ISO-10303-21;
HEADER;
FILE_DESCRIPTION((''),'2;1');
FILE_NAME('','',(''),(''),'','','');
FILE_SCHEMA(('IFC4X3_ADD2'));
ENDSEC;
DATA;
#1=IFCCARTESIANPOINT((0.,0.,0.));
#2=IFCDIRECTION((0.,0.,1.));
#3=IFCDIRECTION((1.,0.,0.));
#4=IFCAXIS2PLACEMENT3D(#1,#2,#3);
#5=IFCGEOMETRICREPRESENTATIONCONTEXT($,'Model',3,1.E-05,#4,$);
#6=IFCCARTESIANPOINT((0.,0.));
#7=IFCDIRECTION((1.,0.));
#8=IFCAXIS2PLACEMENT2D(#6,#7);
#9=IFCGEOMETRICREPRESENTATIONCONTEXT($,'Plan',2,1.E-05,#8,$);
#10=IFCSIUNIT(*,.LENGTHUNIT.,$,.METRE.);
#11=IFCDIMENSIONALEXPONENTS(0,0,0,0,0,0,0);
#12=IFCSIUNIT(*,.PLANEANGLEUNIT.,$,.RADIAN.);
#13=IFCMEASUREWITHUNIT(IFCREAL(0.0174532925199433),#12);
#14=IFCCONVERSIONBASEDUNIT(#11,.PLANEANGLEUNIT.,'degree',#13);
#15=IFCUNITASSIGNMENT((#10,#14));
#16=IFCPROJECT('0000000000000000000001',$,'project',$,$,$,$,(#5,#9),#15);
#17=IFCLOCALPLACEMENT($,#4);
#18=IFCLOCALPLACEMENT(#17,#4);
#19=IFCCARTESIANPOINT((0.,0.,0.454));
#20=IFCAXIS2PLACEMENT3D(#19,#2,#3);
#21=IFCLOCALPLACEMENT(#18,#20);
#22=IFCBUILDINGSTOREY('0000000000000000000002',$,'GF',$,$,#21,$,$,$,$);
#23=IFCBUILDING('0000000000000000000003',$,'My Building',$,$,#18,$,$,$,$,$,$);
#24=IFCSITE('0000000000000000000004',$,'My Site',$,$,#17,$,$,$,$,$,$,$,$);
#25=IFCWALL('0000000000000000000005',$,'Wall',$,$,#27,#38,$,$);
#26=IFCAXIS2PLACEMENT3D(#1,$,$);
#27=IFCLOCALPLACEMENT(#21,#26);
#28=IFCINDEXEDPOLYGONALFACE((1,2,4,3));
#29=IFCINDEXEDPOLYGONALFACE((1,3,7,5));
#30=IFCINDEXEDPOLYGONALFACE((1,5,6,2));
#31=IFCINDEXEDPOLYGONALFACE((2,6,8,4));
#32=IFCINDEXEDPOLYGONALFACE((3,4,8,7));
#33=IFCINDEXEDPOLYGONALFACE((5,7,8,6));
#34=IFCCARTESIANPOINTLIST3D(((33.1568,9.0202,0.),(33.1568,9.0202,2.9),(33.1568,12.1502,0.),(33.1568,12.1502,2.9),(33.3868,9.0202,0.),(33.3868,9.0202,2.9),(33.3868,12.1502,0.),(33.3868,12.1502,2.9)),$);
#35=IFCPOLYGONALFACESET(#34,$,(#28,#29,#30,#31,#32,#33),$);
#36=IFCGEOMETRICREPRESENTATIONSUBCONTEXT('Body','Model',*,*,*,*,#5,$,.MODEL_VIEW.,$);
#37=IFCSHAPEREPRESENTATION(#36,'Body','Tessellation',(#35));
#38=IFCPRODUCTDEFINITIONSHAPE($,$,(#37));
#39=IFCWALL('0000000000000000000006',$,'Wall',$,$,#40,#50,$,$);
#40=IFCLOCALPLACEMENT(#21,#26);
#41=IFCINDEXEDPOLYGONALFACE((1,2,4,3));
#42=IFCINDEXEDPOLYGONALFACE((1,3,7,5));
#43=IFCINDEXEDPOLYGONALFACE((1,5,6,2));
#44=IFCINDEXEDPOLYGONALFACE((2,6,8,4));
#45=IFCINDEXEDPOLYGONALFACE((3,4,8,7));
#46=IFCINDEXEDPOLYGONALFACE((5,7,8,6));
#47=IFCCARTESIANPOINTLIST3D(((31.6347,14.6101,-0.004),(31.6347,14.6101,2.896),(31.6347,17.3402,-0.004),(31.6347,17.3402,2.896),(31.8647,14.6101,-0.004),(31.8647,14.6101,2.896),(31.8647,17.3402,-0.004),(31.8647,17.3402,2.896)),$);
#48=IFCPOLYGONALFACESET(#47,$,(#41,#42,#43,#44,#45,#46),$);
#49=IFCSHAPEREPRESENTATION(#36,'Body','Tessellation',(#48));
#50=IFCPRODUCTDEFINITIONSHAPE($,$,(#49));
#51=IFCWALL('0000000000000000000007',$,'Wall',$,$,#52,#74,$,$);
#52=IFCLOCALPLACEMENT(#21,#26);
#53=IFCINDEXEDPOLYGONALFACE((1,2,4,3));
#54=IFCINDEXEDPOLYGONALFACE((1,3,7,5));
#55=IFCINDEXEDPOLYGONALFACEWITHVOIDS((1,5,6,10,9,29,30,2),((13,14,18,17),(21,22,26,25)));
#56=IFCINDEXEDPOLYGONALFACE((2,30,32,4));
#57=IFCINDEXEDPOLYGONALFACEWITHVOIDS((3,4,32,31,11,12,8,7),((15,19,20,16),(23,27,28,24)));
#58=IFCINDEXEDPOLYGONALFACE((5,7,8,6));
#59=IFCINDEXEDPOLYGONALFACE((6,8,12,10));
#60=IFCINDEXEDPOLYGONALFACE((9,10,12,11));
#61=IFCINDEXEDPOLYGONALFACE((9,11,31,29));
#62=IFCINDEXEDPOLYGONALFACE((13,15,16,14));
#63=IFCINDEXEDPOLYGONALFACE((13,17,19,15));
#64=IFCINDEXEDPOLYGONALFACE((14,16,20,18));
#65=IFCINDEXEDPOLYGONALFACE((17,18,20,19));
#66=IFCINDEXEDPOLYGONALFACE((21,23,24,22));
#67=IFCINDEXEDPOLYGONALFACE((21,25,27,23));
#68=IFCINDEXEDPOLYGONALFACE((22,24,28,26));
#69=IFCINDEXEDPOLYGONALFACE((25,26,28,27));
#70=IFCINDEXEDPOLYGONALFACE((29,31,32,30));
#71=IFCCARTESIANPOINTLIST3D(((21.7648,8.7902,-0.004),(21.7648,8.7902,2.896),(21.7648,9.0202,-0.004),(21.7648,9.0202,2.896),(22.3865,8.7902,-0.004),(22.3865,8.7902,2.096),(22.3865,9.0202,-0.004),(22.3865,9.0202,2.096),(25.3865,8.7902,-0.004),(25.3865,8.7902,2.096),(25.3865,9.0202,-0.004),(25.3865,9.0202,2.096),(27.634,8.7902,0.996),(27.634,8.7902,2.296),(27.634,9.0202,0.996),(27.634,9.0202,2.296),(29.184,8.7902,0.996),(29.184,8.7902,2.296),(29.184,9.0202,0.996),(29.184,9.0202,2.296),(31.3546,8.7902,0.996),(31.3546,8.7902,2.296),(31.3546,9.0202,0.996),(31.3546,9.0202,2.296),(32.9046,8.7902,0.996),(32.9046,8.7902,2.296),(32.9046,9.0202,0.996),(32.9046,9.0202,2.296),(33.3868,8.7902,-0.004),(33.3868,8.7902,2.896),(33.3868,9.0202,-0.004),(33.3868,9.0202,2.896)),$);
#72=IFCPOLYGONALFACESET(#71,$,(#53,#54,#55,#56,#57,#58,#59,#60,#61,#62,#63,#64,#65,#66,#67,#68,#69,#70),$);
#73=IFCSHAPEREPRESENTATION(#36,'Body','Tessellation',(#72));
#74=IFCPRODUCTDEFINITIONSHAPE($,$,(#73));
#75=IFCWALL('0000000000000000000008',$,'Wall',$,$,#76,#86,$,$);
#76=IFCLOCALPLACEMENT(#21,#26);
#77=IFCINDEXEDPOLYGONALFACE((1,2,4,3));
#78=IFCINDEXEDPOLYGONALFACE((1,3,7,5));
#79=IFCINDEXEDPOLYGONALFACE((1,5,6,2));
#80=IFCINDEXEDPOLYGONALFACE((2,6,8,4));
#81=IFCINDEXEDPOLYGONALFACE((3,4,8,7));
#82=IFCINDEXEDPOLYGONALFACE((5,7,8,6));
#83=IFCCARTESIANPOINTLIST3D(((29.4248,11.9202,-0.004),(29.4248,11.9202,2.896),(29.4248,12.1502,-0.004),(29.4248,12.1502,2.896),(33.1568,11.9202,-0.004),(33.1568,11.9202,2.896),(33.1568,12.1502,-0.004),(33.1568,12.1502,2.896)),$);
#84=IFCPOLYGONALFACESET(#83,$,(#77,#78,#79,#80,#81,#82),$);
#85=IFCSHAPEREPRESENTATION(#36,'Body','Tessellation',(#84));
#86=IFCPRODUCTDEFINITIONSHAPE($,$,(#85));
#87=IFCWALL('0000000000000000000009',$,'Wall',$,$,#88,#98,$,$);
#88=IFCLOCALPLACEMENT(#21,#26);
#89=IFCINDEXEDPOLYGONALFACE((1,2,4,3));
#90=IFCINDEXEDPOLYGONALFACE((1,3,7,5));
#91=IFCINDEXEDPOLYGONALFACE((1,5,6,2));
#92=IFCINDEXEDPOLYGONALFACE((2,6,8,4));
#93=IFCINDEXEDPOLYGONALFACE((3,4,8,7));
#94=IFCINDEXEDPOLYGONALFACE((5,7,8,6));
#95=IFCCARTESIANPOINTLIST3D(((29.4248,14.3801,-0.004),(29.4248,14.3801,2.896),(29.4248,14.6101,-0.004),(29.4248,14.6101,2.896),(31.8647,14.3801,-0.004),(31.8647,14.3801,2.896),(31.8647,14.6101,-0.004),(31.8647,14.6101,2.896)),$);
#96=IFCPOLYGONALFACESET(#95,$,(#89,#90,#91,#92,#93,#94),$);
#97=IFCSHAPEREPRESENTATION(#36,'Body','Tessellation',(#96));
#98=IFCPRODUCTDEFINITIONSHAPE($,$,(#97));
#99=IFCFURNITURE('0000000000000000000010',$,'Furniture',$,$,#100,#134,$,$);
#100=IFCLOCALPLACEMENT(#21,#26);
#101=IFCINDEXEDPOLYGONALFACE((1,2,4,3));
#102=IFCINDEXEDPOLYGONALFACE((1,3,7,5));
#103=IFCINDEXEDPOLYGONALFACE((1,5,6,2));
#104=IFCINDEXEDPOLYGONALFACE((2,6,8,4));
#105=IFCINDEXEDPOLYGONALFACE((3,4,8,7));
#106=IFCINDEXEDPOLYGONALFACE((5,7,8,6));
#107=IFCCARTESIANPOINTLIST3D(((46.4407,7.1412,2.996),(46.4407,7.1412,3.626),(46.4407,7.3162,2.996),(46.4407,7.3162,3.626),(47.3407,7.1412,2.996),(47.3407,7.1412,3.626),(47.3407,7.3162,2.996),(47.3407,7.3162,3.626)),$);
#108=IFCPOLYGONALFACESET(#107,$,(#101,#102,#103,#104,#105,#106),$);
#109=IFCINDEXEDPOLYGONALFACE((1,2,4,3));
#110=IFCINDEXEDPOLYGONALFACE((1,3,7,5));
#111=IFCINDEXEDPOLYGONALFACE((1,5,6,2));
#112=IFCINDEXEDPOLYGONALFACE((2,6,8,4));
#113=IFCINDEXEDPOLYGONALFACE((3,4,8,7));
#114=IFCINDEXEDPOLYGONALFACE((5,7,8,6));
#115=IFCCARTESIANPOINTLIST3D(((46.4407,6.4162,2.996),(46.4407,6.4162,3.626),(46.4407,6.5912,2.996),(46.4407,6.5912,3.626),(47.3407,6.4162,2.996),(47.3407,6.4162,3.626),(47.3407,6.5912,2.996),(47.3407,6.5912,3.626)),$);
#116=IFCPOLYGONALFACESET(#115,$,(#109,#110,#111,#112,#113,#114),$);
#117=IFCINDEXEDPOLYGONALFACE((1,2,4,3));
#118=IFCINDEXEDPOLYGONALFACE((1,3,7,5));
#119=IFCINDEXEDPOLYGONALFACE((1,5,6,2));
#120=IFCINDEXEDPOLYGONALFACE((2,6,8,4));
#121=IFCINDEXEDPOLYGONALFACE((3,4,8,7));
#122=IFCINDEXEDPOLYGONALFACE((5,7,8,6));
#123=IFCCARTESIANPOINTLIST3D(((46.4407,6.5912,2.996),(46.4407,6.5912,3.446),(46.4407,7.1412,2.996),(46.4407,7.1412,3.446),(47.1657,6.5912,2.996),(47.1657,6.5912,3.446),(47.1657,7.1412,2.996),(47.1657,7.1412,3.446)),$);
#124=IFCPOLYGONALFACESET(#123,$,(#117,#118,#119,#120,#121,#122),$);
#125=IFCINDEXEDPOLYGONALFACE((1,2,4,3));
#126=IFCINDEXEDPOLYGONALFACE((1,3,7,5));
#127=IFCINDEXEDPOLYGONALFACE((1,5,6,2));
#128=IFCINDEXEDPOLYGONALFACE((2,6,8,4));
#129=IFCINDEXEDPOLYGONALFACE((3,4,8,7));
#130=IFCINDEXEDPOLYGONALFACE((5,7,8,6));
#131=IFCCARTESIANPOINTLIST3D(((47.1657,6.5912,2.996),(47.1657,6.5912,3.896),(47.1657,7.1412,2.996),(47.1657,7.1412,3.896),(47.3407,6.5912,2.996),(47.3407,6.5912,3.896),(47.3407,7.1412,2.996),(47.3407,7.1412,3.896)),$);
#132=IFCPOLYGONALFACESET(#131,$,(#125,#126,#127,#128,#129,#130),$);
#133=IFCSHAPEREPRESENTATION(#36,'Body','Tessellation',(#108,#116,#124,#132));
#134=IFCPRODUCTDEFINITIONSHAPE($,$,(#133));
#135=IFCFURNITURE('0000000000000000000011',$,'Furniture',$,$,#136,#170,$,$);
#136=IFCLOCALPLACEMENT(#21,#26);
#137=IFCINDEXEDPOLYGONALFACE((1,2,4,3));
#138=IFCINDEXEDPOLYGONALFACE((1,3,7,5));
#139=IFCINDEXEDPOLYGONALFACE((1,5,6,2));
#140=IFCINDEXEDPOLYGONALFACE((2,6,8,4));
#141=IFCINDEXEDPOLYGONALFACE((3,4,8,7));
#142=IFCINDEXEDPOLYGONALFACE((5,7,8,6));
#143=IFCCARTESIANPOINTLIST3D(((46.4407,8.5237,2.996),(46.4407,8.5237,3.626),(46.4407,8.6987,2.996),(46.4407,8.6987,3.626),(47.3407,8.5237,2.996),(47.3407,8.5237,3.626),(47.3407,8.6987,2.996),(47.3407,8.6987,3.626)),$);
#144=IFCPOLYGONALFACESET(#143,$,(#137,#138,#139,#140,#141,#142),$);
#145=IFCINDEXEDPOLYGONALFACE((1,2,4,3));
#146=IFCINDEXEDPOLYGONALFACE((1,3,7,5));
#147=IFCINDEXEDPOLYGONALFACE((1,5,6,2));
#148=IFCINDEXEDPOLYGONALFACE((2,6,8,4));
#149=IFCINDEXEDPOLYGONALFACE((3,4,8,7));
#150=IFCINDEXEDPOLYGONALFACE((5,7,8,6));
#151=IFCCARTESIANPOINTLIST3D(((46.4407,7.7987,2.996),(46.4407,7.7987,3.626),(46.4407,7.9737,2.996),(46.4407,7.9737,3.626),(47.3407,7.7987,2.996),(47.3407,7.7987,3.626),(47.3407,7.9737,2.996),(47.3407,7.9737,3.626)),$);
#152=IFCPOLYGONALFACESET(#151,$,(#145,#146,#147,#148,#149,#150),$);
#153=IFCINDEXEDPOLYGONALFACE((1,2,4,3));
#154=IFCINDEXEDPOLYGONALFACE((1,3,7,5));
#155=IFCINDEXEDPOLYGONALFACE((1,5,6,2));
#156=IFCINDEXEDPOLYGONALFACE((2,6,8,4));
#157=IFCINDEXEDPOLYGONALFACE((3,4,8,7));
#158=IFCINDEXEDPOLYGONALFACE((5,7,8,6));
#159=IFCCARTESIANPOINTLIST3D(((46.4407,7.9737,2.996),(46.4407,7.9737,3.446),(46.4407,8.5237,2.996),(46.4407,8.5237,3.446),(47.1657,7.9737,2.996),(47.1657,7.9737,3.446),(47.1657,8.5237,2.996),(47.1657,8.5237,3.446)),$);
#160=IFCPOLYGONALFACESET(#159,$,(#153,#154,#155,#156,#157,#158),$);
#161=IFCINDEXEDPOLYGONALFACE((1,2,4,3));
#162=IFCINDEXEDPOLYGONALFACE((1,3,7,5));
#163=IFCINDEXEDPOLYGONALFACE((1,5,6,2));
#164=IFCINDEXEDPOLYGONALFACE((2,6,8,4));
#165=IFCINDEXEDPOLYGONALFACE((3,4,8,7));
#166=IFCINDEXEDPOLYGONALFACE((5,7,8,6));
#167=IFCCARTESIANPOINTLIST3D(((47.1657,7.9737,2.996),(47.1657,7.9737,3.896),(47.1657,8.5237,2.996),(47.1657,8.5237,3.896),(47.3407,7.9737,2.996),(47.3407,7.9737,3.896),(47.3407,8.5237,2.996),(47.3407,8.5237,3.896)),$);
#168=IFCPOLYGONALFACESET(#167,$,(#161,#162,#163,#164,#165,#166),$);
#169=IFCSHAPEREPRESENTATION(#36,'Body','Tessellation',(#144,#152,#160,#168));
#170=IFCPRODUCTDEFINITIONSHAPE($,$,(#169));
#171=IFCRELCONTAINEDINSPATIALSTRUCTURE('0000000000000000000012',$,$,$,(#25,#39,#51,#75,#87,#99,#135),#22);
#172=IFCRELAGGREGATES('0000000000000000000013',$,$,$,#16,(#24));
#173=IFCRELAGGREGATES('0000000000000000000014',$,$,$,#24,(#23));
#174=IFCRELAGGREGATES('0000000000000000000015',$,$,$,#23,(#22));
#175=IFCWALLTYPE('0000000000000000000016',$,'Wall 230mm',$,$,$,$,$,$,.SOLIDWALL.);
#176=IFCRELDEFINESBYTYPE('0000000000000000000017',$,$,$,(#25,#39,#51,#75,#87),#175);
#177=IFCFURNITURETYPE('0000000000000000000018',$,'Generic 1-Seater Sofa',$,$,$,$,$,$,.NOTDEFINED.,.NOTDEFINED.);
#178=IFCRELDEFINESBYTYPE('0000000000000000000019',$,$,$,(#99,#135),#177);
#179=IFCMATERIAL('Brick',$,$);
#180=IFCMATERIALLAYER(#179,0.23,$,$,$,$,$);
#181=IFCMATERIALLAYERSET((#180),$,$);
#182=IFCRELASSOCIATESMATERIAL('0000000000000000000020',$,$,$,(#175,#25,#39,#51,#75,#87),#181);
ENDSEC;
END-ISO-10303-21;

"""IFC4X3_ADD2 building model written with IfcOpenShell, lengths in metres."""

from ifc_helpers import new_model, entity, si_unit, converted_unit, frame, origin_with_axes, origin_2d_with_axis, place, context, subcontext, project, spatial, line, indexed_curve, outline, extrude, shape, source, transform, mapped, material, layer, layer_set, layer_usage, type_object, type_shapes, element, save


model = new_model("IFC4X3_ADD2")

# Units and contexts
model_context = context("Model", 3, precision=1e-05, world=origin_with_axes())
plan_context = context("Plan", 2, precision=1e-05, world=origin_2d_with_axis())
body_context_1 = subcontext(model_context, "Body", "Model", "MODEL_VIEW")
body_context_2 = subcontext(plan_context, "Body", "Plan", "PLAN_VIEW")
ifc_project = project(units=[si_unit("LENGTHUNIT", "METRE"), converted_unit("PLANEANGLEUNIT", "degree", entity("IfcReal", 0.0174532925199433), si_unit("PLANEANGLEUNIT", "RADIAN"), dimensions=[0, 0, 0, 0, 0, 0, 0])], contexts=[model_context, plan_context])

# Site, building, storey
site_placement = place(None, origin_with_axes())
site = spatial("IfcSite", under=ifc_project, at=site_placement, Name="My Site")
building_placement = place(site_placement, origin_with_axes())
building = spatial("IfcBuilding", under=site, at=building_placement, Name="My Building")
storey_placement = place(building_placement, frame((0.0, 0.0, 0.454), z_axis=(0.0, 0.0, 1.0), x_axis=(1.0, 0.0, 0.0)))
storey = spatial("IfcBuildingStorey", under=building, at=storey_placement, Name="GF")

# Walls
ifc_material = material(Name="Brick")
ifc_layer = layer(ifc_material, 0.23)
ifc_layer_set = layer_set([ifc_layer])
ifc_layer_usage_1 = layer_usage(ifc_layer_set, "AXIS2", "POSITIVE", 0.0)
wall_type = type_object("IfcWallType", Name="Wall 230mm", PredefinedType="SOLIDWALL", material=ifc_layer_set)
wall_1_placement = place(storey_placement, frame((33.3868, 9.0202, 0.0), z_axis=(0.0, 0.0, 1.0), x_axis=(0.000001, 1.0, 0.0)))
element("IfcWall", 1, at=wall_1_placement, inside=storey, type_object=wall_type, material=ifc_layer_usage_1, Name="Wall", context=body_context_1, shape_type="SweptSolid", body=[
    extrude(outline(indexed_curve([(0.0, 0.0), (0.0, 0.23), (3.13, 0.23), (3.13, 0.0), (0.0, 0.0)], self_intersect=False)), origin_with_axes(), (0.0, 0.0, 1.0), 2.9),
])
ifc_layer_usage_2 = layer_usage(ifc_layer_set, "AXIS2", "POSITIVE", 0.0)
wall_2_placement = place(storey_placement, frame((31.8647, 14.6101, -0.004), z_axis=(0.0, 0.0, 1.0), x_axis=(0.000001, 1.0, 0.0)))
element("IfcWall", 2, at=wall_2_placement, inside=storey, type_object=wall_type, material=ifc_layer_usage_2, Name="Wall", context=body_context_1, shape_type="SweptSolid", body=[
    extrude(outline(indexed_curve([(0.0, 0.0), (0.0, 0.23), (2.73, 0.23), (2.73, 0.0), (0.0, 0.0)], self_intersect=False)), origin_with_axes(), (0.0, 0.0, 1.0), 2.9),
])

# Wall, openings
ifc_layer_usage_3 = layer_usage(ifc_layer_set, "AXIS2", "POSITIVE", 0.0)
wall_3_placement = place(storey_placement, frame((33.3868, 9.0202, -0.004), z_axis=(0.0, 0.0, 1.0), x_axis=(-1.0, 0.0, 0.0)))
wall_3 = element("IfcWall", 3, at=wall_3_placement, inside=storey, type_object=wall_type, material=ifc_layer_usage_3, Name="Wall", context=body_context_1, shape_type="SweptSolid", body=[
    extrude(outline(indexed_curve([(0.0, 0.0), (0.0, 0.23), (11.622, 0.23), (11.622, 0.0), (0.0, 0.0)], self_intersect=False)), origin_with_axes(), (0.0, 0.0, 1.0), 2.9),
])
shared_shape_1 = source(origin_with_axes(), body_context_1, "Body", "SweptSolid", [
    extrude(outline(indexed_curve([(0.0, 0.0), (3.0, 0.0), (3.0, 2.1), (0.0, 2.1)], segments=[line(1, 2, 3, 4, 1)])), frame((0.0, -0.6, 0.0), z_axis=(0.0, -1.0, 0.0), x_axis=(1.0, 0.0, 0.0)), (0.0, 0.0, -1.0), 1.2),
])
opening_1_placement = place(wall_3_placement, frame((8.0003, 0.0, 0.0), z_axis=(0.0, 0.0, 1.0), x_axis=(1.0, 0.0, 0.0)))
element("IfcOpeningElement", 4, at=opening_1_placement, cuts=wall_3, PredefinedType="OPENING", context=body_context_1, shape_type="MappedRepresentation", body=[
    mapped(shared_shape_1, transform((0.0, 0.0, 0.0), x_axis=(1.0, 0.0, 0.0), y_axis=(0.0, 1.0, 0.0), z_axis=(0.0, 0.0, 1.0), scale=1.0)),
])
shared_shape_2 = source(origin_with_axes(), body_context_1, "Body", "SweptSolid", [
    extrude(outline(indexed_curve([(0.0, 0.0), (1.55, 0.0), (1.55, 1.3), (0.0, 1.3)], segments=[line(1, 2, 3, 4, 1)])), frame((-0.775, -0.6, 0.0), z_axis=(0.0, -1.0, 0.0), x_axis=(1.0, 0.0, 0.0)), (0.0, 0.0, -1.0), 1.2),
])
opening_2_placement = place(wall_3_placement, frame((1.2571, 0.0, 1.0), z_axis=(0.0, 0.0, 1.0), x_axis=(1.0, 0.0, 0.0)))
element("IfcOpeningElement", 5, at=opening_2_placement, cuts=wall_3, PredefinedType="OPENING", context=body_context_1, shape_type="MappedRepresentation", body=[
    mapped(shared_shape_2, transform((0.0, 0.0, 0.0), x_axis=(1.0, 0.0, 0.0), y_axis=(0.0, 1.0, 0.0), z_axis=(0.0, 0.0, 1.0), scale=1.0)),
])
opening_3_placement = place(wall_3_placement, frame((4.9778, 0.0, 1.0), z_axis=(0.0, 0.0, 1.0), x_axis=(1.0, 0.0, 0.0)))
element("IfcOpeningElement", 6, at=opening_3_placement, cuts=wall_3, PredefinedType="OPENING", context=body_context_1, shape_type="MappedRepresentation", body=[
    mapped(shared_shape_2, transform((0.0, 0.0, 0.0), x_axis=(1.0, 0.0, 0.0), y_axis=(0.0, 1.0, 0.0), z_axis=(0.0, 0.0, 1.0), scale=1.0)),
])

# Walls
ifc_layer_usage_4 = layer_usage(ifc_layer_set, "AXIS2", "POSITIVE", 0.0)
wall_4_placement = place(storey_placement, frame((33.1568, 12.1502, -0.004), z_axis=(0.0, 0.0, 1.0), x_axis=(-1.0, 0.0, 0.0)))
element("IfcWall", 7, at=wall_4_placement, inside=storey, type_object=wall_type, material=ifc_layer_usage_4, Name="Wall", context=body_context_1, shape_type="SweptSolid", body=[
    extrude(outline(indexed_curve([(0.0, 0.0), (0.0, 0.23), (3.732, 0.23), (3.732, 0.0), (0.0, 0.0)], self_intersect=False)), origin_with_axes(), (0.0, 0.0, 1.0), 2.9),
])
ifc_layer_usage_5 = layer_usage(ifc_layer_set, "AXIS2", "POSITIVE", 0.0)
wall_5_placement = place(storey_placement, frame((31.8647, 14.6101, -0.004), z_axis=(0.0, 0.0, 1.0), x_axis=(-1.0, 0.0, 0.0)))
element("IfcWall", 8, at=wall_5_placement, inside=storey, type_object=wall_type, material=ifc_layer_usage_5, Name="Wall", context=body_context_1, shape_type="SweptSolid", body=[
    extrude(outline(indexed_curve([(0.0, 0.0), (0.0, 0.23), (2.44, 0.23), (2.44, 0.0), (0.0, 0.0)], self_intersect=False)), origin_with_axes(), (0.0, 0.0, 1.0), 2.9),
])

# Furniture
furniture_type_1 = type_object("IfcFurnitureType", Name="Generic 1-Seater Sofa", AssemblyPlace="NOTDEFINED", PredefinedType="NOTDEFINED")
shared_shape_3 = source(origin_with_axes(), body_context_1, "Body", "SweptSolid", [
    extrude(outline(indexed_curve([(0.0, 0.0), (0.175, 0.0), (0.175, 0.9), (0.0, 0.9)], segments=[line(1, 2, 3, 4, 1)])), frame((-0.45, -0.9, 0.0), z_axis=(0.0, 0.0, 1.0), x_axis=(1.0, 0.0, 0.0)), (0.0, 0.0, 1.0), 0.63),
    extrude(outline(indexed_curve([(0.0, 0.0), (0.175, 0.0), (0.175, 0.9), (0.0, 0.9)], segments=[line(1, 2, 3, 4, 1)])), frame((0.275, -0.9, 0.0), z_axis=(0.0, 0.0, 1.0), x_axis=(1.0, 0.0, 0.0)), (0.0, 0.0, 1.0), 0.63),
    extrude(outline(indexed_curve([(0.175, 0.0), (0.725, 0.0), (0.725, 0.725), (0.175, 0.725)], segments=[line(1, 2, 3, 4, 1)])), frame((-0.45, -0.9, 0.0), z_axis=(0.0, 0.0, 1.0), x_axis=(1.0, 0.0, 0.0)), (0.0, 0.0, 1.0), 0.45),
    extrude(outline(indexed_curve([(0.175, 0.725), (0.725, 0.725), (0.725, 0.9), (0.175, 0.9)], segments=[line(1, 2, 3, 4, 1)])), frame((-0.45, -0.9, 0.0), z_axis=(0.0, 0.0, 1.0), x_axis=(1.0, 0.0, 0.0)), (0.0, 0.0, 1.0), 0.9),
])
shared_shape_4 = source(origin_with_axes(), body_context_2, "Body", "Annotation2D", [
    entity("IfcGeometricCurveSet", [entity("IfcIndexedPolyCurve", entity("IfcCartesianPointList2D", [[0.275, -0.175], [0.275, -0.9], [0.45, -0.9], [0.45, 0.0], [0.275, 0.0], [0.275, -0.9], [-0.275, -0.9], [-0.275, 0.0], [-0.275, -0.175], [0.275, -0.175], [0.275, 0.0], [-0.275, 0.0], [-0.45, 0.0], [-0.45, -0.9], [-0.275, -0.9], [-0.275, -0.175]]))]),
])
type_shapes(furniture_type_1, [shared_shape_3, shared_shape_4])
for number, where, z_axis, x_axis, name in (
    (9, (47.3407, 6.8662, 2.996), (0.0, 0.0, 1.0), (0.0, -1.0, 0.0), "Furniture"),
    (10, (47.3407, 8.2487, 2.996), (0.0, 0.0, 1.0), (0.0, -1.0, 0.0), "Furniture"),
):
    element("IfcFurniture", number, at=place(storey_placement, frame(where, z_axis=z_axis, x_axis=x_axis)), inside=storey, type_object=furniture_type_1, Name=name, shapes=[
        shape(body_context_1, "Body", "MappedRepresentation", [mapped(shared_shape_3, transform((0.0, 0.0, 0.0), x_axis=(1.0, 0.0, 0.0), y_axis=(0.0, 1.0, 0.0), z_axis=(0.0, 0.0, 1.0), scale=1.0))]),
        shape(body_context_2, "Body", "MappedRepresentation", [mapped(shared_shape_4, transform((0.0, 0.0, 0.0), x_axis=(1.0, 0.0, 0.0), y_axis=(0.0, 1.0, 0.0), z_axis=(0.0, 0.0, 1.0), scale=1.0))]),
    ])

save(model, "model.ifc")
